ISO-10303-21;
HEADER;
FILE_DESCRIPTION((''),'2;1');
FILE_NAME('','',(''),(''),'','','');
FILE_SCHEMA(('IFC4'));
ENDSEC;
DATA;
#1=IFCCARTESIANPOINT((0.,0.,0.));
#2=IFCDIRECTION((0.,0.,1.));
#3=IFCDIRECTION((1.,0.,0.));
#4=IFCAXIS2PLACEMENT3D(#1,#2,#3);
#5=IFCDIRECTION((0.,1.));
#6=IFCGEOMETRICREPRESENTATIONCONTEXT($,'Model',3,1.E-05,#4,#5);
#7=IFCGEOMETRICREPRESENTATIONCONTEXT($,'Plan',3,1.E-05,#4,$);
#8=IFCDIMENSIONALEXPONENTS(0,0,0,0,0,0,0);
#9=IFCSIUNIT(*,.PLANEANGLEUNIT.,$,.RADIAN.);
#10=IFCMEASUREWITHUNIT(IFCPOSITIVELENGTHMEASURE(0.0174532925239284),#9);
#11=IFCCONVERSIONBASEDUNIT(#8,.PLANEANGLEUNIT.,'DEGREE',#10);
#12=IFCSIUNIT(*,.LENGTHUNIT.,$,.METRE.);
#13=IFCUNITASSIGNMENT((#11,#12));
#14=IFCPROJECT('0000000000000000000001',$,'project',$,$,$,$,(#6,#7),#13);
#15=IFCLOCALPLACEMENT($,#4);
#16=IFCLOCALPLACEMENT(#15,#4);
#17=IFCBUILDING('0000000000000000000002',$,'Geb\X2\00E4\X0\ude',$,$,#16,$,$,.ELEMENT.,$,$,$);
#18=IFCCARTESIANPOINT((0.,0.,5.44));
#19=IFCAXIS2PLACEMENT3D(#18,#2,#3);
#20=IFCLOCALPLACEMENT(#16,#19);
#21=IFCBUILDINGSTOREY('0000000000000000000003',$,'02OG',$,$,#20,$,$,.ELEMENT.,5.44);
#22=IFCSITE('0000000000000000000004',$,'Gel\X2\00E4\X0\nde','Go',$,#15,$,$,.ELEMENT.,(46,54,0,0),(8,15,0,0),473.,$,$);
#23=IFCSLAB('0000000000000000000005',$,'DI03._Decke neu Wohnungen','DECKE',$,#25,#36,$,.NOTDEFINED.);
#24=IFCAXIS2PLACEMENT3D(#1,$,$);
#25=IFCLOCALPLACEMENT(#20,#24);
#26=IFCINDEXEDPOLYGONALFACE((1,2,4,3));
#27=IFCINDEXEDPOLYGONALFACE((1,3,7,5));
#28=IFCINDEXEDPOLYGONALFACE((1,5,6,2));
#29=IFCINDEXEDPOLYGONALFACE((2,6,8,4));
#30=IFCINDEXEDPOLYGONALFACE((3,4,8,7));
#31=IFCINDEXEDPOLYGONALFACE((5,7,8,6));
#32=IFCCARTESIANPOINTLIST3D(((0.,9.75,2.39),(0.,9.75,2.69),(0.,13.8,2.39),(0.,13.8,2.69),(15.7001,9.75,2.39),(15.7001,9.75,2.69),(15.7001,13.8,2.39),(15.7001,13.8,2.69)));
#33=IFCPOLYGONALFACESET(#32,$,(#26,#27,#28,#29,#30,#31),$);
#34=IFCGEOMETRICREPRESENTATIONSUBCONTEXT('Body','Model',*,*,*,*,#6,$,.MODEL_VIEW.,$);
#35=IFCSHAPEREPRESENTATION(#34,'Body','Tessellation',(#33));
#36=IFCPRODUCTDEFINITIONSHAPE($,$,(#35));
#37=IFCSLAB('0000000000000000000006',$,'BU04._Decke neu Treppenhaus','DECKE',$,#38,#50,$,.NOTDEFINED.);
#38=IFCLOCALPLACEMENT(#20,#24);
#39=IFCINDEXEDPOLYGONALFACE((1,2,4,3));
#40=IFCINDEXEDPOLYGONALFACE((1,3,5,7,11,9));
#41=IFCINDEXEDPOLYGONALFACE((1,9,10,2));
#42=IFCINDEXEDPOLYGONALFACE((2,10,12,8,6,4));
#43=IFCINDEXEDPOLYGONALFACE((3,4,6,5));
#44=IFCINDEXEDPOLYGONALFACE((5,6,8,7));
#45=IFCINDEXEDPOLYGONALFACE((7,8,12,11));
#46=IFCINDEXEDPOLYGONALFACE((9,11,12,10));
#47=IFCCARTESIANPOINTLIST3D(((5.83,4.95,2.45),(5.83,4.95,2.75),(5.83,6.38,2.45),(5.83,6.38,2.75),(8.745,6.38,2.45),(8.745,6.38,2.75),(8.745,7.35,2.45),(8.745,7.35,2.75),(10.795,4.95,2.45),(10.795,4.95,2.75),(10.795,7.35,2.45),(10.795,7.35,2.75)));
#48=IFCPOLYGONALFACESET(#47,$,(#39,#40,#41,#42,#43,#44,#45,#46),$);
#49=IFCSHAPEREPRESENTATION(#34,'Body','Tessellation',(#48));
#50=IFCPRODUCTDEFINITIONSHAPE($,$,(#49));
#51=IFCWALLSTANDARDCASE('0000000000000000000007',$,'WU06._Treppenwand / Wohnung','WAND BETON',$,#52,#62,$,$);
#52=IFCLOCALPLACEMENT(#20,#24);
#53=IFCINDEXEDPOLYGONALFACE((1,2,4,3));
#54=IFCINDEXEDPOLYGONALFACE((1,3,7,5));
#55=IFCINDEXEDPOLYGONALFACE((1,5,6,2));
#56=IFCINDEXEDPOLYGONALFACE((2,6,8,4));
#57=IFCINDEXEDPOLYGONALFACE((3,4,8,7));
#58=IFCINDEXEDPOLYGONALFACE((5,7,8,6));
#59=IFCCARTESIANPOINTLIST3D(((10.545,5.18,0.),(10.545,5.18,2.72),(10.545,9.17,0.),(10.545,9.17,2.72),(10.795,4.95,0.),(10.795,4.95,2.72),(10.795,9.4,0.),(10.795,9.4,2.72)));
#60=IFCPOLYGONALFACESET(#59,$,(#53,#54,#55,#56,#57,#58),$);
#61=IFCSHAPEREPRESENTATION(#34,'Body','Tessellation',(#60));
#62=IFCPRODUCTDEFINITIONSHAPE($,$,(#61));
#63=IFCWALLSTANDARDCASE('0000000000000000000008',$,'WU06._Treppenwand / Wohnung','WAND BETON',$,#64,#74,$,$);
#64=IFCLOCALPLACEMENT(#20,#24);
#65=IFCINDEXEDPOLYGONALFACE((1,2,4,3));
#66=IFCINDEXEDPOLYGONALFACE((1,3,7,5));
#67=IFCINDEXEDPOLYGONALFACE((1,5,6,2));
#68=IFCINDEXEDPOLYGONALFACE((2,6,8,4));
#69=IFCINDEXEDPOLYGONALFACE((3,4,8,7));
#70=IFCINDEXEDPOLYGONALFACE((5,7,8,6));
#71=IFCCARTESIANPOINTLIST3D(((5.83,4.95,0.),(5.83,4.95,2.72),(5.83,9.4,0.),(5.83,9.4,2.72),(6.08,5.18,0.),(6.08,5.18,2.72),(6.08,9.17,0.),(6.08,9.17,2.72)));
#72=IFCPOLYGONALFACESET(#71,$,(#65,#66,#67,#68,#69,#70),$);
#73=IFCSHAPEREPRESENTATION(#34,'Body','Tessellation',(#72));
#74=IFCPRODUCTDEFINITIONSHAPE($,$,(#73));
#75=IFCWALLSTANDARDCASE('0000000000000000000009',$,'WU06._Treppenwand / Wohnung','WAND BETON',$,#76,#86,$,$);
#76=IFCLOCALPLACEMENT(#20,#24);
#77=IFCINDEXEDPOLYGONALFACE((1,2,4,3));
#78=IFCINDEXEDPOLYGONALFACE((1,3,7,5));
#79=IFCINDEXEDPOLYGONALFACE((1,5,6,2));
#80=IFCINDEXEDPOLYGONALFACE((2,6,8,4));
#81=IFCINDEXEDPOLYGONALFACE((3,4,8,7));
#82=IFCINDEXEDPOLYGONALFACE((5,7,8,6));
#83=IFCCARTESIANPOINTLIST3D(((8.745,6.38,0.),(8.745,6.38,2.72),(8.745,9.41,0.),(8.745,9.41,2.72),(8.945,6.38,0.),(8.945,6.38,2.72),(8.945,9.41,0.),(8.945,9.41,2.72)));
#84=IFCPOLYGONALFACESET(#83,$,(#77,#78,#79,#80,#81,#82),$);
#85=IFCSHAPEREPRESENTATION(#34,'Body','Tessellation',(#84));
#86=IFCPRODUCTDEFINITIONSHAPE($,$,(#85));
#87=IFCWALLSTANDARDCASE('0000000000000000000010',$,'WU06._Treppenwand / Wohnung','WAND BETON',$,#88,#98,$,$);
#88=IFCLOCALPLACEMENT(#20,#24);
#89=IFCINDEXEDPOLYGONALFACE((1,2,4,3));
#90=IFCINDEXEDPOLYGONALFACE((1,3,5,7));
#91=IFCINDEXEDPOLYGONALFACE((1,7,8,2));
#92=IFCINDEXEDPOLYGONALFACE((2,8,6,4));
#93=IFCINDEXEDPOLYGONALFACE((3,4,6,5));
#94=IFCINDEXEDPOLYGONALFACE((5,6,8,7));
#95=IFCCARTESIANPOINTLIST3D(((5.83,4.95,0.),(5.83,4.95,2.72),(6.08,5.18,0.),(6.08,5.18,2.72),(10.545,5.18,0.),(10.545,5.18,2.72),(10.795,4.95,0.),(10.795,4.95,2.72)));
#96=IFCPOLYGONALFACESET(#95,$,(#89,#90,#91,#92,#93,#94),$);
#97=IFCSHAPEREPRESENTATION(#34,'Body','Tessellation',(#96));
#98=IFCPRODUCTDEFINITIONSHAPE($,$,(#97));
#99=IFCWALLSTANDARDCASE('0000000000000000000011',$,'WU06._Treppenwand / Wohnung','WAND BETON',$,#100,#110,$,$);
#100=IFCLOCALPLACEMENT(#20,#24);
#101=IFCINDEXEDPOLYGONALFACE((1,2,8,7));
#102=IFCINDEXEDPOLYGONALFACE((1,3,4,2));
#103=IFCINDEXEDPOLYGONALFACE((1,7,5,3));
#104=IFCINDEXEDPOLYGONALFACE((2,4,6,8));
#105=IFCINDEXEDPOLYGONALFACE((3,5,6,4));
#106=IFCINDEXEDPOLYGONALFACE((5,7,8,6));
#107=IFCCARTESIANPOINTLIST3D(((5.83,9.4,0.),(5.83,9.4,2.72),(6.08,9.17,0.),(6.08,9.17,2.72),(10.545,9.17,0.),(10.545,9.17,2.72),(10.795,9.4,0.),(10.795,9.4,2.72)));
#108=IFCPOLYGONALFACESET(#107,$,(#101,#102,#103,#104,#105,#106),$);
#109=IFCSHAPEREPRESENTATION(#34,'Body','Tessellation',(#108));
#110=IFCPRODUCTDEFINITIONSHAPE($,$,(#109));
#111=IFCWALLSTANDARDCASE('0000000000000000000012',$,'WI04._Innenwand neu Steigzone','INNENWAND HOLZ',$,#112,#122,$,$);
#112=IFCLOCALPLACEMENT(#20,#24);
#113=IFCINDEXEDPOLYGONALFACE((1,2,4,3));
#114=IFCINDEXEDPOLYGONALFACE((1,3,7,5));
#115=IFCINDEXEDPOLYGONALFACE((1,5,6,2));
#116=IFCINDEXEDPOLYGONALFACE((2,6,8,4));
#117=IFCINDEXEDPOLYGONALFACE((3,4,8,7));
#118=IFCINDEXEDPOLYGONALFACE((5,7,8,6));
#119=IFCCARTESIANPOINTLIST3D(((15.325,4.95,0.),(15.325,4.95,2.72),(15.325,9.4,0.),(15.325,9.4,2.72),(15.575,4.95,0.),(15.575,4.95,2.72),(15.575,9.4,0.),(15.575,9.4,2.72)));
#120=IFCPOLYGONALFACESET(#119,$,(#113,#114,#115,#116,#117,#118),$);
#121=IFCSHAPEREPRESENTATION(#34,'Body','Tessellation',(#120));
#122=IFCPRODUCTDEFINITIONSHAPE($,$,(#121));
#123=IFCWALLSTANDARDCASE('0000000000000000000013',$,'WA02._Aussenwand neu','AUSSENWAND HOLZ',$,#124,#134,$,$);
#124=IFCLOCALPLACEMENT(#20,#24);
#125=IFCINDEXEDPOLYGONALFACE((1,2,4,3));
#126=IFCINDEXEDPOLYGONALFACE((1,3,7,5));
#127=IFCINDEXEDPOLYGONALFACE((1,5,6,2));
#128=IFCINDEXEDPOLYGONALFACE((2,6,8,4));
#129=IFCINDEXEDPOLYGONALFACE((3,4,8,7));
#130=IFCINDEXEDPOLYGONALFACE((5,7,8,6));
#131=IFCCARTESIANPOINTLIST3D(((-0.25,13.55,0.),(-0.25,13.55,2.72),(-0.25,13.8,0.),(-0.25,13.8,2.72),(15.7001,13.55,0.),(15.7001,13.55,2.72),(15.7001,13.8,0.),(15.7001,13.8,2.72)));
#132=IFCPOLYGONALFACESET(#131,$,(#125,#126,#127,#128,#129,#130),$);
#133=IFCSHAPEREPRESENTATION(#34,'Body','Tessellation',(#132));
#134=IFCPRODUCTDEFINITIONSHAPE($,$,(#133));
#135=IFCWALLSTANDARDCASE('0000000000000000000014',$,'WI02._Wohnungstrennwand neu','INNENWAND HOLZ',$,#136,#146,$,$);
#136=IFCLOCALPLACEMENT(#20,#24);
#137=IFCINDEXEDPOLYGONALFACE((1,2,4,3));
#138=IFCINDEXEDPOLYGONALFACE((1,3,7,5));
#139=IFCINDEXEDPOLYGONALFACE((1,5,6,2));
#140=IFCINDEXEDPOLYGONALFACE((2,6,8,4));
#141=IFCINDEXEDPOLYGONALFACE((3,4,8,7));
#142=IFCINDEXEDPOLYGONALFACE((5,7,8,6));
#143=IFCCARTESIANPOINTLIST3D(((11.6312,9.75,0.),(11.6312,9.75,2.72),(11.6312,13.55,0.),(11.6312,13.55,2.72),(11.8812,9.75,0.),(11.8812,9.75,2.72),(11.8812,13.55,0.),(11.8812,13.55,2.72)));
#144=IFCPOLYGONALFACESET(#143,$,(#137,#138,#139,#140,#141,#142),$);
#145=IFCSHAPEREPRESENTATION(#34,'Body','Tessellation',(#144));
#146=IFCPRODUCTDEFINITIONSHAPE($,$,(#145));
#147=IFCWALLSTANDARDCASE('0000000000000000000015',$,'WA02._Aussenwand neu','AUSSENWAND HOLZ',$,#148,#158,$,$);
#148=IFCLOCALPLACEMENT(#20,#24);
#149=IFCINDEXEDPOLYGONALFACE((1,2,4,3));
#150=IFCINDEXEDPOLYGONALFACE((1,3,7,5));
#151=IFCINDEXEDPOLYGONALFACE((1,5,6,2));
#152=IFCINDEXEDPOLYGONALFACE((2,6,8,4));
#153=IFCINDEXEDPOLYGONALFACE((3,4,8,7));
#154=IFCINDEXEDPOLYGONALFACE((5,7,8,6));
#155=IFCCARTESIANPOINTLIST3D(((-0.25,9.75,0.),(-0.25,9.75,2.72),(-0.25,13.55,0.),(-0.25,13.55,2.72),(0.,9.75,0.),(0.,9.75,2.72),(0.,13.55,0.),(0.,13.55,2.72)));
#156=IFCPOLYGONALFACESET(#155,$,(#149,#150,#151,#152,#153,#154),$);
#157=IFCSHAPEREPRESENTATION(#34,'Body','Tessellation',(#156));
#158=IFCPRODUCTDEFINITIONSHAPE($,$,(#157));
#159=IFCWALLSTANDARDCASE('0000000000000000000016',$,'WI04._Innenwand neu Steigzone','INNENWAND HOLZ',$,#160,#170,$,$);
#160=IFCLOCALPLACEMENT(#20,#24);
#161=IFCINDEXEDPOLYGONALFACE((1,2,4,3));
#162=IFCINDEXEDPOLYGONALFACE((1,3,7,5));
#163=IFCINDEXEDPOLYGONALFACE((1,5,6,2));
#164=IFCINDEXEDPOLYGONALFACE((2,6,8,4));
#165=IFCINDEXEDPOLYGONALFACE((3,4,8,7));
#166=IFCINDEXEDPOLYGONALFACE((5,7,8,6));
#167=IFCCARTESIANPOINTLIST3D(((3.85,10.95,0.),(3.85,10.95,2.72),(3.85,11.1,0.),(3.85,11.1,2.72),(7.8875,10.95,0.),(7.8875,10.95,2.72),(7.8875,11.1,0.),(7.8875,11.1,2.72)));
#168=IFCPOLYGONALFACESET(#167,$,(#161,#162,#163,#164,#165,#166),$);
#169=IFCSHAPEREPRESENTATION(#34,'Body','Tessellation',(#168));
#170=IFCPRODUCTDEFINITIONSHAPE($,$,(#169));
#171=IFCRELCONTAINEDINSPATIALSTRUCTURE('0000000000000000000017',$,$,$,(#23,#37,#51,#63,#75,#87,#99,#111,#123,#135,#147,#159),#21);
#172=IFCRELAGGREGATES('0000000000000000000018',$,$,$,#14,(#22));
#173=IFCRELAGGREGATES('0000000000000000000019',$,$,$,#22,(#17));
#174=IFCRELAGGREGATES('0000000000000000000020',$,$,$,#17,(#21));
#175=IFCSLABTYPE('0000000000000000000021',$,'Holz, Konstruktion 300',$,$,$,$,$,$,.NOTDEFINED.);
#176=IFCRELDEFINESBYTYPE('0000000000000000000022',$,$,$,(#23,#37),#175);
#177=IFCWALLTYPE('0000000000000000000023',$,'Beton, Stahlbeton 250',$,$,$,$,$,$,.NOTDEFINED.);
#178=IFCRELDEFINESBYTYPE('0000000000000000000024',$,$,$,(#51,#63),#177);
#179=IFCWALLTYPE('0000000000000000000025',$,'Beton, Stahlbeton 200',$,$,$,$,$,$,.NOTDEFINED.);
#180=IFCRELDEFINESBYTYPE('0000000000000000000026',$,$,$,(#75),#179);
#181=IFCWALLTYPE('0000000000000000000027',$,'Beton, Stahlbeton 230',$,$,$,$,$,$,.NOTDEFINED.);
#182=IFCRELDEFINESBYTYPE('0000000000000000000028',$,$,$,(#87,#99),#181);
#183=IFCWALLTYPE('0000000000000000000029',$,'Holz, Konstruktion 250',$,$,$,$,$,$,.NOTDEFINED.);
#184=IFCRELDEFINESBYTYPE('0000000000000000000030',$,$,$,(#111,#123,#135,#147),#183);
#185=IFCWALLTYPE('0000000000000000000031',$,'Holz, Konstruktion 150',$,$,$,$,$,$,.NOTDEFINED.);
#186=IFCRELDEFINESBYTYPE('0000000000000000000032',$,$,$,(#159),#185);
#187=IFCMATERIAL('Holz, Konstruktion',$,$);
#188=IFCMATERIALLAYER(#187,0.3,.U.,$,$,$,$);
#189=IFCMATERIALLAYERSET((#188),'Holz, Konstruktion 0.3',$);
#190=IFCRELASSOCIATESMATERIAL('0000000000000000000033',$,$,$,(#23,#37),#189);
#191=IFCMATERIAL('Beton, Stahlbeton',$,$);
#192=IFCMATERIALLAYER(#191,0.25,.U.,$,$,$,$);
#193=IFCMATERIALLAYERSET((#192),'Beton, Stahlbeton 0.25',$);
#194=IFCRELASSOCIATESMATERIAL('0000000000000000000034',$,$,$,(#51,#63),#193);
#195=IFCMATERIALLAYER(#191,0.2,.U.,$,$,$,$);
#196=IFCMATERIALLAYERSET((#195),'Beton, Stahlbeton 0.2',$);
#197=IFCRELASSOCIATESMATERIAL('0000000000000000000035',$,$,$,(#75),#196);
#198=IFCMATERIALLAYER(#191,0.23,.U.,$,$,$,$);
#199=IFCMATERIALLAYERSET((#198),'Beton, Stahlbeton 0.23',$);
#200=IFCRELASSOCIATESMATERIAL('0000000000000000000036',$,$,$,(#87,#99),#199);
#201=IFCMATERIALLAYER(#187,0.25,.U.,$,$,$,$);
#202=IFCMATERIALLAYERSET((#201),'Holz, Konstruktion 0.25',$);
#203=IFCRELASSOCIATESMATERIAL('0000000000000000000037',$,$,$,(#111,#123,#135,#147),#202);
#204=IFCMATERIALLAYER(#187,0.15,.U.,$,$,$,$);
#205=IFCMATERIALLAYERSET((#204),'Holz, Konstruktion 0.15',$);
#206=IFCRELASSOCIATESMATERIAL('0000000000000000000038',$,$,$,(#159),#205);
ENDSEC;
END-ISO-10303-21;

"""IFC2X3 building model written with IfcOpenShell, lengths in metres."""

from ifc_helpers import new_model, entity, si_unit, converted_unit, direction, frame, origin_with_axes, place, context, subcontext, project, spatial, polyline, outline, extrude, material, layer, layer_set, layer_usage, type_object, element, save


model = new_model("IFC2X3")

# Units and contexts
model_context = context("Model", 3, precision=1e-05, world=origin_with_axes(), true_north=direction((0.0, 1.0)))
plan_context = context("Plan", 3, precision=1e-05, world=origin_with_axes())
body_context = subcontext(model_context, "Body", "Model", "MODEL_VIEW")
ifc_project = project(units=[converted_unit("PLANEANGLEUNIT", "DEGREE", entity("IfcPositiveLengthMeasure", 0.0174532925239284), si_unit("PLANEANGLEUNIT", "RADIAN"), dimensions=[0, 0, 0, 0, 0, 0, 0]), si_unit("LENGTHUNIT", "METRE")], contexts=[model_context, plan_context])

# Site, building, storey
site_placement = place(None, origin_with_axes())
site = spatial("IfcSite", under=ifc_project, at=site_placement, Name="Gelände", Description="Go", CompositionType="ELEMENT", RefLatitude=(46, 54, 0, 0), RefLongitude=(8, 15, 0, 0), RefElevation=473.0)
building_placement = place(site_placement, origin_with_axes())
building = spatial("IfcBuilding", under=site, at=building_placement, Name="Gebäude", CompositionType="ELEMENT")
storey_placement = place(building_placement, frame((0.0, 0.0, 5.44), z_axis=(0.0, 0.0, 1.0), x_axis=(1.0, 0.0, 0.0)))
storey = spatial("IfcBuildingStorey", under=building, at=storey_placement, Name="02OG", CompositionType="ELEMENT", Elevation=5.44)

# Slabs
ifc_material_1 = material(Name="Holz, Konstruktion")
ifc_layer_1 = layer(ifc_material_1, 0.3, ventilated="UNKNOWN")
ifc_layer_set_1 = layer_set([ifc_layer_1], Name="Holz, Konstruktion 0.3")
ifc_layer_usage_1 = layer_usage(ifc_layer_set_1, "AXIS3", "NEGATIVE", 0.3)
slab_type = type_object("IfcSlabType", Name="Holz, Konstruktion 300", PredefinedType="NOTDEFINED")
slab_1_placement = place(storey_placement, frame((0.0, 9.75, 2.69), z_axis=(0.0, 0.0, 1.0), x_axis=(1.0, 0.0, 0.0)))
element("IfcSlab", 1, at=slab_1_placement, inside=storey, type_object=slab_type, material=ifc_layer_usage_1, Name="DI03._Decke neu Wohnungen", Description="DECKE", PredefinedType="NOTDEFINED", context=body_context, shape_type="SweptSolid", body=[
    extrude(outline(polyline([(0.0, 0.0), (15.7001, 0.0), (15.7001, 4.05), (0.0, 4.05), (0.0, 0.0)])), frame((0.0, 0.0, -0.3), z_axis=(0.0, 0.0, 1.0), x_axis=(1.0, 0.0, 0.0)), (0.0, 0.0, 1.0), 0.3),
])
ifc_layer_usage_2 = layer_usage(ifc_layer_set_1, "AXIS3", "NEGATIVE", 0.3)
slab_2_placement = place(storey_placement, frame((10.795, 7.35, 2.75), z_axis=(0.0, 0.0, 1.0), x_axis=(1.0, 0.0, 0.0)))
element("IfcSlab", 2, at=slab_2_placement, inside=storey, type_object=slab_type, material=ifc_layer_usage_2, Name="BU04._Decke neu Treppenhaus", Description="DECKE", PredefinedType="NOTDEFINED", context=body_context, shape_type="SweptSolid", body=[
    extrude(outline(polyline([(0.0, 0.0), (-2.05, 0.0), (-2.05, -0.97), (-4.965, -0.97), (-4.965, -2.4), (0.0, -2.4), (0.0, 0.0)])), frame((0.0, 0.0, -0.3), z_axis=(0.0, 0.0, 1.0), x_axis=(1.0, 0.0, 0.0)), (0.0, 0.0, 1.0), 0.3),
])

# Walls
ifc_material_2 = material(Name="Beton, Stahlbeton")
ifc_layer_2 = layer(ifc_material_2, 0.25, ventilated="UNKNOWN")
ifc_layer_set_2 = layer_set([ifc_layer_2], Name="Beton, Stahlbeton 0.25")
ifc_layer_usage_3 = layer_usage(ifc_layer_set_2, "AXIS2", "POSITIVE", -0.25)
wall_type_1 = type_object("IfcWallType", Name="Beton, Stahlbeton 250", PredefinedType="NOTDEFINED")
wall_1_placement = place(storey_placement, frame((10.545, 5.18, 0.0), z_axis=(0.0, 0.0, 1.0), x_axis=(0.0, 1.0, 0.0)))
element("IfcWallStandardCase", 3, at=wall_1_placement, inside=storey, type_object=wall_type_1, material=ifc_layer_usage_3, Name="WU06._Treppenwand / Wohnung", Description="WAND BETON", context=body_context, shape_type="SweptSolid", body=[
    extrude(outline(polyline([(-0.23, -0.25), (4.22, -0.25), (3.99, 0.0), (0.0, 0.0), (-0.23, -0.25)])), origin_with_axes(), (0.0, 0.0, 1.0), 2.72),
])
ifc_layer_usage_4 = layer_usage(ifc_layer_set_2, "AXIS2", "POSITIVE", -0.25)
wall_2_placement = place(storey_placement, frame((6.08, 9.17, 0.0), z_axis=(0.0, 0.0, 1.0), x_axis=(0.0, -1.0, 0.0)))
element("IfcWallStandardCase", 4, at=wall_2_placement, inside=storey, type_object=wall_type_1, material=ifc_layer_usage_4, Name="WU06._Treppenwand / Wohnung", Description="WAND BETON", context=body_context, shape_type="SweptSolid", body=[
    extrude(outline(polyline([(-0.23, -0.25), (4.22, -0.25), (3.99, 0.0), (0.0, 0.0), (-0.23, -0.25)])), origin_with_axes(), (0.0, 0.0, 1.0), 2.72),
])
ifc_layer_3 = layer(ifc_material_2, 0.2, ventilated="UNKNOWN")
ifc_layer_set_3 = layer_set([ifc_layer_3], Name="Beton, Stahlbeton 0.2")
ifc_layer_usage_5 = layer_usage(ifc_layer_set_3, "AXIS2", "NEGATIVE", 0.2)
wall_type_2 = type_object("IfcWallType", Name="Beton, Stahlbeton 200", PredefinedType="NOTDEFINED")
wall_3_placement = place(storey_placement, frame((8.945, 6.38, 0.0), z_axis=(0.0, 0.0, 1.0), x_axis=(0.0, 1.0, 0.0)))
element("IfcWallStandardCase", 5, at=wall_3_placement, inside=storey, type_object=wall_type_2, material=ifc_layer_usage_5, Name="WU06._Treppenwand / Wohnung", Description="WAND BETON", context=body_context, shape_type="SweptSolid", body=[
    extrude(outline(polyline([(0.0, 0.0), (3.03, 0.0), (3.03, 0.2), (0.0, 0.2), (0.0, 0.0)])), origin_with_axes(), (0.0, 0.0, 1.0), 2.72),
])
ifc_layer_4 = layer(ifc_material_2, 0.23, ventilated="UNKNOWN")
ifc_layer_set_4 = layer_set([ifc_layer_4], Name="Beton, Stahlbeton 0.23")
ifc_layer_usage_6 = layer_usage(ifc_layer_set_4, "AXIS2", "POSITIVE", -0.23)
wall_type_3 = type_object("IfcWallType", Name="Beton, Stahlbeton 230", PredefinedType="NOTDEFINED")
wall_4_placement = place(storey_placement, frame((6.08, 5.18, 0.0), z_axis=(0.0, 0.0, 1.0), x_axis=(1.0, 0.0, 0.0)))
element("IfcWallStandardCase", 6, at=wall_4_placement, inside=storey, type_object=wall_type_3, material=ifc_layer_usage_6, Name="WU06._Treppenwand / Wohnung", Description="WAND BETON", context=body_context, shape_type="SweptSolid", body=[
    extrude(outline(polyline([(-0.25, -0.23), (4.715, -0.23), (4.465, 0.0), (0.0, 0.0), (-0.25, -0.23)])), origin_with_axes(), (0.0, 0.0, 1.0), 2.72),
])
ifc_layer_usage_7 = layer_usage(ifc_layer_set_4, "AXIS2", "POSITIVE", -0.23)
wall_5_placement = place(storey_placement, frame((10.545, 9.17, 0.0), z_axis=(0.0, 0.0, 1.0), x_axis=(-1.0, 0.0, 0.0)))
element("IfcWallStandardCase", 7, at=wall_5_placement, inside=storey, type_object=wall_type_3, material=ifc_layer_usage_7, Name="WU06._Treppenwand / Wohnung", Description="WAND BETON", context=body_context, shape_type="SweptSolid", body=[
    extrude(outline(polyline([(-0.25, -0.23), (4.715, -0.23), (4.465, 0.0), (0.0, 0.0), (-0.25, -0.23)])), origin_with_axes(), (0.0, 0.0, 1.0), 2.72),
])
ifc_layer_5 = layer(ifc_material_1, 0.25, ventilated="UNKNOWN")
ifc_layer_set_5 = layer_set([ifc_layer_5], Name="Holz, Konstruktion 0.25")
wall_type_4 = type_object("IfcWallType", Name="Holz, Konstruktion 250", PredefinedType="NOTDEFINED")
ifc_layer_usage_8 = layer_usage(ifc_layer_set_5, "AXIS2", "NEGATIVE", 0.0)
wall_6_placement = place(storey_placement, frame((15.325, 4.95, 0.0), z_axis=(0.0, 0.0, 1.0), x_axis=(0.0, 1.0, 0.0)))
element("IfcWallStandardCase", 8, at=wall_6_placement, inside=storey, type_object=wall_type_4, material=ifc_layer_usage_8, Name="WI04._Innenwand neu Steigzone", Description="INNENWAND HOLZ", context=body_context, shape_type="SweptSolid", body=[
    extrude(outline(polyline([(0.0, -0.25), (4.45, -0.25), (4.45, 0.0), (0.0, 0.0), (0.0, -0.25)])), origin_with_axes(), (0.0, 0.0, 1.0), 2.72),
])
ifc_layer_usage_9 = layer_usage(ifc_layer_set_5, "AXIS2", "NEGATIVE", 0.0)
wall_7_placement = place(storey_placement, frame((-0.25, 13.8, 0.0), z_axis=(0.0, 0.0, 1.0), x_axis=(1.0, 0.0, 0.0)))
element("IfcWallStandardCase", 9, at=wall_7_placement, inside=storey, type_object=wall_type_4, material=ifc_layer_usage_9, Name="WA02._Aussenwand neu", Description="AUSSENWAND HOLZ", context=body_context, shape_type="SweptSolid", body=[
    extrude(outline(polyline([(0.0, -0.25), (15.9501, -0.25), (15.9501, 0.0), (0.0, 0.0), (0.0, -0.25)])), origin_with_axes(), (0.0, 0.0, 1.0), 2.72),
])
ifc_layer_usage_10 = layer_usage(ifc_layer_set_5, "AXIS2", "NEGATIVE", 0.0)
wall_8_placement = place(storey_placement, frame((11.8812, 13.55, 0.0), z_axis=(0.0, 0.0, 1.0), x_axis=(0.0, -1.0, 0.0)))
element("IfcWallStandardCase", 10, at=wall_8_placement, inside=storey, type_object=wall_type_4, material=ifc_layer_usage_10, Name="WI02._Wohnungstrennwand neu", Description="INNENWAND HOLZ", context=body_context, shape_type="SweptSolid", body=[
    extrude(outline(polyline([(0.0, -0.25), (3.8, -0.25), (3.8, 0.0), (0.0, 0.0), (0.0, -0.25)])), origin_with_axes(), (0.0, 0.0, 1.0), 2.72),
])
ifc_layer_usage_11 = layer_usage(ifc_layer_set_5, "AXIS2", "NEGATIVE", 0.0)
wall_9_placement = place(storey_placement, frame((-0.25, 9.75, 0.0), z_axis=(0.0, 0.0, 1.0), x_axis=(0.0, 1.0, 0.0)))
element("IfcWallStandardCase", 11, at=wall_9_placement, inside=storey, type_object=wall_type_4, material=ifc_layer_usage_11, Name="WA02._Aussenwand neu", Description="AUSSENWAND HOLZ", context=body_context, shape_type="SweptSolid", body=[
    extrude(outline(polyline([(0.0, -0.25), (3.8, -0.25), (3.8, 0.0), (0.0, 0.0), (0.0, -0.25)])), origin_with_axes(), (0.0, 0.0, 1.0), 2.72),
])
ifc_layer_6 = layer(ifc_material_1, 0.15, ventilated="UNKNOWN")
ifc_layer_set_6 = layer_set([ifc_layer_6], Name="Holz, Konstruktion 0.15")
ifc_layer_usage_12 = layer_usage(ifc_layer_set_6, "AXIS2", "POSITIVE", 0.0)
wall_type_5 = type_object("IfcWallType", Name="Holz, Konstruktion 150", PredefinedType="NOTDEFINED")
wall_10_placement = place(storey_placement, frame((3.85, 10.95, 0.0), z_axis=(0.0, 0.0, 1.0), x_axis=(1.0, 0.0, 0.0)))
element("IfcWallStandardCase", 12, at=wall_10_placement, inside=storey, type_object=wall_type_5, material=ifc_layer_usage_12, Name="WI04._Innenwand neu Steigzone", Description="INNENWAND HOLZ", context=body_context, shape_type="SweptSolid", body=[
    extrude(outline(polyline([(0.0, 0.0), (4.0375, 0.0), (4.0375, 0.15), (0.0, 0.15), (0.0, 0.0)])), origin_with_axes(), (0.0, 0.0, 1.0), 2.72),
])

save(model, "model.ifc")
